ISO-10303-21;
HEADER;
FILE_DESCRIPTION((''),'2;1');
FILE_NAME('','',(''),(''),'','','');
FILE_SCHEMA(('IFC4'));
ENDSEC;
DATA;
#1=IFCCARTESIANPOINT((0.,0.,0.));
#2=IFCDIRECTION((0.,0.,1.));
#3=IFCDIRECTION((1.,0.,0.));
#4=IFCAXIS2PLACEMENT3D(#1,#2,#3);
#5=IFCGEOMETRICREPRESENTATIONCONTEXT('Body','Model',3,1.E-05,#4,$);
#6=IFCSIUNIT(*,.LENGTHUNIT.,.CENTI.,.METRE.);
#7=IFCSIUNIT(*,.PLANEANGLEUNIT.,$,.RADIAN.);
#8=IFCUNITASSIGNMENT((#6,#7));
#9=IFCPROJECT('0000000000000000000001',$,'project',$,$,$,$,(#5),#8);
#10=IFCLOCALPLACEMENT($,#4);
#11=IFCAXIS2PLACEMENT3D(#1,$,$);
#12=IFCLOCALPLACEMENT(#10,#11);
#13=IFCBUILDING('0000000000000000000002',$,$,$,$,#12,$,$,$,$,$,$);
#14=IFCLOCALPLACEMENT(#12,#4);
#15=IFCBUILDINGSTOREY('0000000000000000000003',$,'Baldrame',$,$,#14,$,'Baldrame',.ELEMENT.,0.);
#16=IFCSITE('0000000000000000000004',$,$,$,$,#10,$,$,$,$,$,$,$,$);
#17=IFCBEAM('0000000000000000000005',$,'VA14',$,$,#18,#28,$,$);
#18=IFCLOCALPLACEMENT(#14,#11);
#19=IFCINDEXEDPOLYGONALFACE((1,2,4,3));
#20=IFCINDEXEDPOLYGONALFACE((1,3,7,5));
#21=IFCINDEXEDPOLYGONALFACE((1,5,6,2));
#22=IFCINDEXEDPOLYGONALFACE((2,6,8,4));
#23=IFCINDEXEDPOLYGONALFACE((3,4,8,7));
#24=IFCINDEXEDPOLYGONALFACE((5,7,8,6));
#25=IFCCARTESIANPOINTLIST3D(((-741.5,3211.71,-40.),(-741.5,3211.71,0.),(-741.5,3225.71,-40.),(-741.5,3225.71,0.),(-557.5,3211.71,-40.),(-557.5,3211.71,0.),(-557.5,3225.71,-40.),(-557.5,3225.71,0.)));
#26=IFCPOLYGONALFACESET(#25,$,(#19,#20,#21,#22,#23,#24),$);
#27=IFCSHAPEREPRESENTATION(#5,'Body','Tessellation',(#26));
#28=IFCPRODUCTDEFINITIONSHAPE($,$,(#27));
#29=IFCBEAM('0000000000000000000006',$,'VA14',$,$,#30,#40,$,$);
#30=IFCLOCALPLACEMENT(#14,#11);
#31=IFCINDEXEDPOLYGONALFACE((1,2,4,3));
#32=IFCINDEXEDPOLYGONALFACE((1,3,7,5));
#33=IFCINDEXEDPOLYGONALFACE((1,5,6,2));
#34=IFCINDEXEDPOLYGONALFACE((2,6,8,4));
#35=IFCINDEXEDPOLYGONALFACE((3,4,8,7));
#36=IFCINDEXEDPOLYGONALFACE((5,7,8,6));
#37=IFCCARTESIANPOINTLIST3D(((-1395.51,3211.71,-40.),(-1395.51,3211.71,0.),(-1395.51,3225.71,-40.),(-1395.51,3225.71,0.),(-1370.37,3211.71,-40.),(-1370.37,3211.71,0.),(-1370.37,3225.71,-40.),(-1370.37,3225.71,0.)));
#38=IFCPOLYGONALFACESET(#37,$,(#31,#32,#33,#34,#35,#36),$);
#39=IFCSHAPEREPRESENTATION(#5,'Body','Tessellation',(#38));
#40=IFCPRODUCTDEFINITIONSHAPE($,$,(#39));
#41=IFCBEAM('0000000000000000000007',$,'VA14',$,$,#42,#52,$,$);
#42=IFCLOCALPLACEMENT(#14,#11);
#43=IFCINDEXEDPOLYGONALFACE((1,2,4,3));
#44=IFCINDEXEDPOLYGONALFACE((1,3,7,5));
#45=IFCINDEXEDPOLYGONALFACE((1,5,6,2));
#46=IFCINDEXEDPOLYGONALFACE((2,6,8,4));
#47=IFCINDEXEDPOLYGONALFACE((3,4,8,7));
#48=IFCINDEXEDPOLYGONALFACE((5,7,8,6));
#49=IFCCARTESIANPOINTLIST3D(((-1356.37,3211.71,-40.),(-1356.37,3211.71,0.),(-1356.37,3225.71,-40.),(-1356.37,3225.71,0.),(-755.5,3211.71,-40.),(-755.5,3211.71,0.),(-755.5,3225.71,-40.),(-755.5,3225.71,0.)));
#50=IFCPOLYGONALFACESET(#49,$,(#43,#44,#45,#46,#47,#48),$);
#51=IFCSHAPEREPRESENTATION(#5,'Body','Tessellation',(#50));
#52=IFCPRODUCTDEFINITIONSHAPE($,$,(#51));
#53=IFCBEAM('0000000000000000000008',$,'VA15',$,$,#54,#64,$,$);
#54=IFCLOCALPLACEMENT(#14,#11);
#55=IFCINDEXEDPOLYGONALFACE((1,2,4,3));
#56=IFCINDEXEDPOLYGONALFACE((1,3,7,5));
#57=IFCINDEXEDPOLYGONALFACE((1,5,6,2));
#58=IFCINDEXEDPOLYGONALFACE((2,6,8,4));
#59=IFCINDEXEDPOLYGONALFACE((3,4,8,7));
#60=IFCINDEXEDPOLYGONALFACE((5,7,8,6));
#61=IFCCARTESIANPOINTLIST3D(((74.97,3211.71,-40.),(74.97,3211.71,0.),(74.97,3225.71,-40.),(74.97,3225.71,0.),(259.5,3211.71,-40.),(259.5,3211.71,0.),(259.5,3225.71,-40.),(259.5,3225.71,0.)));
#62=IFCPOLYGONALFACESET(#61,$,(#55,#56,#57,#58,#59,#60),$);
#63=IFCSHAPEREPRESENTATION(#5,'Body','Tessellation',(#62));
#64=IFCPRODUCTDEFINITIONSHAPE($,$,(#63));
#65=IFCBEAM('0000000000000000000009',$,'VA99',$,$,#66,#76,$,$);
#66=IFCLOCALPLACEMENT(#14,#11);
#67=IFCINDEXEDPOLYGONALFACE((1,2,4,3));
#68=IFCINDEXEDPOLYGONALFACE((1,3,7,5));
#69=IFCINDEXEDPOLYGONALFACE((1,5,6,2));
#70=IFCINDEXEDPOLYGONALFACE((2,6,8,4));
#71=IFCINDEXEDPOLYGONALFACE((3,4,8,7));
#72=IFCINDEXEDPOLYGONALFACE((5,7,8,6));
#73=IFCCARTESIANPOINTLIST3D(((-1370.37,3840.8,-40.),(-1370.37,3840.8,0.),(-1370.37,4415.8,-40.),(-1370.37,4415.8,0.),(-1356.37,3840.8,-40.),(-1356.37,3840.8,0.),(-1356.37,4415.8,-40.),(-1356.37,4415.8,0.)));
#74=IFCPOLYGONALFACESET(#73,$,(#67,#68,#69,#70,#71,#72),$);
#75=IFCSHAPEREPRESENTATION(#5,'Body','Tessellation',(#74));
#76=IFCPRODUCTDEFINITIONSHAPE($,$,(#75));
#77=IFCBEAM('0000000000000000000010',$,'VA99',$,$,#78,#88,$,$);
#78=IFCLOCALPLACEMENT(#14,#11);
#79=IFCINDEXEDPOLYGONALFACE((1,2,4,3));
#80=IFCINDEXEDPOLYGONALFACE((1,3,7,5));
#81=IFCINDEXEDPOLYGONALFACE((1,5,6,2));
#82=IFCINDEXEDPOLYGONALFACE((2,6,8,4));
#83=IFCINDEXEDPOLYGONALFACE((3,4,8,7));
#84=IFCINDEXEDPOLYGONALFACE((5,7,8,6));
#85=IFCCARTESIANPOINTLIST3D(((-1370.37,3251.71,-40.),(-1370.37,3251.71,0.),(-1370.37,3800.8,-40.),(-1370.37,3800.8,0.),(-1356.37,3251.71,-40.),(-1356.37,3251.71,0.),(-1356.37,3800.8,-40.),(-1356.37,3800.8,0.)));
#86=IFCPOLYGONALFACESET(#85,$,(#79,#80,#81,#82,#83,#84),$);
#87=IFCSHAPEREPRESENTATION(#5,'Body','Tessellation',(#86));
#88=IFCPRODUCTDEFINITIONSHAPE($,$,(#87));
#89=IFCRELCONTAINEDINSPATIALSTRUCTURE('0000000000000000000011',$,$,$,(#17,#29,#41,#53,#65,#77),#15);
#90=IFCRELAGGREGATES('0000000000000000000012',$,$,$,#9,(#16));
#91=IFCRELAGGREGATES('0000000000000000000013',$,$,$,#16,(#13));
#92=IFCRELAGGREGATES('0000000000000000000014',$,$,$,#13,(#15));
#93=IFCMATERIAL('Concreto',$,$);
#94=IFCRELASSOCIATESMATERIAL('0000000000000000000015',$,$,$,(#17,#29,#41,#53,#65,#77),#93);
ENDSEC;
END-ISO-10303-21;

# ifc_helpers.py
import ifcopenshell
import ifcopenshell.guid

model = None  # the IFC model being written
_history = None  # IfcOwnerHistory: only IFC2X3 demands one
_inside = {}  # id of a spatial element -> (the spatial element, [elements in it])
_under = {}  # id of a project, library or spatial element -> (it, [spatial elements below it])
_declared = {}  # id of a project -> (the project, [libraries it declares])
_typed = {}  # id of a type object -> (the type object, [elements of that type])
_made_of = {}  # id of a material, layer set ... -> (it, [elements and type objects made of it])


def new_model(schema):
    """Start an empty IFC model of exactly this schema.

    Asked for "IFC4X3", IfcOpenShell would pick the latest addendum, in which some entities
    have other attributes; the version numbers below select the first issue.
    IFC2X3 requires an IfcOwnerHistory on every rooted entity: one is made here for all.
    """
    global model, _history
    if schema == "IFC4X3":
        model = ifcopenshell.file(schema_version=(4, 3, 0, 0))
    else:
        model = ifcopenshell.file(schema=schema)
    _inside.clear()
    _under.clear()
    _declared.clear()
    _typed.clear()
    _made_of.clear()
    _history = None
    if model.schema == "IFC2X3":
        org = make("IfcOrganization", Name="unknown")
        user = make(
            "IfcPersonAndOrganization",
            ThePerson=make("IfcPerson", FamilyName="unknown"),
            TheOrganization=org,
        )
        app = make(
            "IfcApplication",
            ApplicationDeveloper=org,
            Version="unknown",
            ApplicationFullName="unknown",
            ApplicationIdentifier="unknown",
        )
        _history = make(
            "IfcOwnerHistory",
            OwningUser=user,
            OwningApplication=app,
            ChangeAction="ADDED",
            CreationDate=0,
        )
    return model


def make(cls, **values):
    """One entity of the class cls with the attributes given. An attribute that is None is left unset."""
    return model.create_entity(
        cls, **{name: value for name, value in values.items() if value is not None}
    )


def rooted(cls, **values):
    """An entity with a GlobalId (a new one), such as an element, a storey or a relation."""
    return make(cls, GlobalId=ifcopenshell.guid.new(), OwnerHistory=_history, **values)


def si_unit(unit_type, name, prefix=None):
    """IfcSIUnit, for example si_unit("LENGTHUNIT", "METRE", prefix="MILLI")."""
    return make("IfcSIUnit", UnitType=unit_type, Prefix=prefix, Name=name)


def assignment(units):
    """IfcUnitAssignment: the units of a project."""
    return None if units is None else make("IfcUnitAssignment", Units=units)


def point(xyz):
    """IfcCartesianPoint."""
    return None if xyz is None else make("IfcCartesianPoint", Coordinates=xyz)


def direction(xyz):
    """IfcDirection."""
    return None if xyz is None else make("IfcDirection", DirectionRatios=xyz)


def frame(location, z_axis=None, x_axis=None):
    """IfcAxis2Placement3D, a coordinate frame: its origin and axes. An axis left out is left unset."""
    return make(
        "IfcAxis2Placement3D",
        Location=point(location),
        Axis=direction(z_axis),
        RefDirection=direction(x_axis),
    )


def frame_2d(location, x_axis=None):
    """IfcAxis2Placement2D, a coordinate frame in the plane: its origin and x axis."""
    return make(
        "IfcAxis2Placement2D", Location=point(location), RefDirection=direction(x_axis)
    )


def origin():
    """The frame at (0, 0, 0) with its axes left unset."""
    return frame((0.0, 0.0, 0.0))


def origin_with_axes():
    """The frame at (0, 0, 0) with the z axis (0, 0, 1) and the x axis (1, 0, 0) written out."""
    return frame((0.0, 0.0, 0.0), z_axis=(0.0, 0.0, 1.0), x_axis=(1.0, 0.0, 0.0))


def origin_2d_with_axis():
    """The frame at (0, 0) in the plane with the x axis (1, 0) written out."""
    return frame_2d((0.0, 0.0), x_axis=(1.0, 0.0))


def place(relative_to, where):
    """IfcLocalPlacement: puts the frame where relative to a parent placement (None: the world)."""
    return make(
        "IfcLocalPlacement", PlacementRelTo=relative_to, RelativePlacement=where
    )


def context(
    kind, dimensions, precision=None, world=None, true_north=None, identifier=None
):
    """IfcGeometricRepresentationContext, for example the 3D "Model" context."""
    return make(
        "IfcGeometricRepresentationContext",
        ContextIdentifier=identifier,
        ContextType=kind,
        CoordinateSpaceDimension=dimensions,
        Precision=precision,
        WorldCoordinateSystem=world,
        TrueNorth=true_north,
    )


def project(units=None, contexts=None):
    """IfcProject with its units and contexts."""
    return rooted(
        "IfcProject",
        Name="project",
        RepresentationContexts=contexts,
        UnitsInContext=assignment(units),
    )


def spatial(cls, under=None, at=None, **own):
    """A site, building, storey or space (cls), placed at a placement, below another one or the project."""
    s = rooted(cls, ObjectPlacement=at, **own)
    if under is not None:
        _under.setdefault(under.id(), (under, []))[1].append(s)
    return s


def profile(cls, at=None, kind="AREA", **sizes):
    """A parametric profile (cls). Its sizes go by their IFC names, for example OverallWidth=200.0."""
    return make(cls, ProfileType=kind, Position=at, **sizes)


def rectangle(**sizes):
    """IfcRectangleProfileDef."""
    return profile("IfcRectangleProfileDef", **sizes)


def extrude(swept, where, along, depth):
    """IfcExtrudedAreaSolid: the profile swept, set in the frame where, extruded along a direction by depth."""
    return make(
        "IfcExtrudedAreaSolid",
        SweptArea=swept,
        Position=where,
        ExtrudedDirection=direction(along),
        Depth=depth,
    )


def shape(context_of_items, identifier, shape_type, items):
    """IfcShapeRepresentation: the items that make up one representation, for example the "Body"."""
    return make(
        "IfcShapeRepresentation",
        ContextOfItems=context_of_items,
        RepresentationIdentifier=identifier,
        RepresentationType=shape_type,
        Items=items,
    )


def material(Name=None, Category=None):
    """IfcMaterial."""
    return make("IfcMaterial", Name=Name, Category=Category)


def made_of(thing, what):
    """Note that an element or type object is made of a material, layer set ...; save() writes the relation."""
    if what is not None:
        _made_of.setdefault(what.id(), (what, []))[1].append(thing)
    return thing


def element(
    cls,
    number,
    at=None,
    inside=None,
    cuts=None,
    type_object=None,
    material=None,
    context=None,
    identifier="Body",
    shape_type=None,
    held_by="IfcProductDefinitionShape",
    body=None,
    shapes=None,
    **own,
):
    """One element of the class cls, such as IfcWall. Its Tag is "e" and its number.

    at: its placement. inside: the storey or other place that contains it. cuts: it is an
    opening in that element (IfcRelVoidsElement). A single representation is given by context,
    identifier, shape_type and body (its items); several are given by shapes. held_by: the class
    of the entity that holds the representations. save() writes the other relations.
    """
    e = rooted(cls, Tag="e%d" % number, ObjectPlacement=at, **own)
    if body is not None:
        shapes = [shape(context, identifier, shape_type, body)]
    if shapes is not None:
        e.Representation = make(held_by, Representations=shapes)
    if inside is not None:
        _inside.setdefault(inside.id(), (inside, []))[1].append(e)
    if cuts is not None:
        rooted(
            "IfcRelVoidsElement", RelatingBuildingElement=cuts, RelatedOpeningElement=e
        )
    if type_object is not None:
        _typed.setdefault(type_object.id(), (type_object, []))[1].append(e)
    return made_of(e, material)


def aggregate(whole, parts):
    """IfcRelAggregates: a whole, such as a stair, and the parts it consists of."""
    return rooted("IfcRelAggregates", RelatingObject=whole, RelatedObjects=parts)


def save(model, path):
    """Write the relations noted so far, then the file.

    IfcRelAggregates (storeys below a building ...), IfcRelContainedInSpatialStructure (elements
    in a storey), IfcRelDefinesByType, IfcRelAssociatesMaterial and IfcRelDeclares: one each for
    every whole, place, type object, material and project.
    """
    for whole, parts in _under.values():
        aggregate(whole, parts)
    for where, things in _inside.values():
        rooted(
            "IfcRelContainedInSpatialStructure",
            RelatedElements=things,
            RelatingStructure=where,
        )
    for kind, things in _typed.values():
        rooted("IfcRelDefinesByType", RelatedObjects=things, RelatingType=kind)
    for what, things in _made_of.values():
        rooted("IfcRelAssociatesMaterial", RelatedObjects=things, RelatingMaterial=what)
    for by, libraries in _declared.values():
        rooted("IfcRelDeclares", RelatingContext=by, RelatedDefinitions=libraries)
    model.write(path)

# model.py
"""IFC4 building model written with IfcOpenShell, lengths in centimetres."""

from ifc_helpers import new_model, si_unit, frame, origin, origin_with_axes, origin_2d_with_axis, place, context, project, spatial, rectangle, extrude, material, element, save


model = new_model("IFC4")

# Units and contexts
model_context = context("Model", 3, precision=1e-05, world=origin_with_axes(), identifier="Body")
ifc_project = project(units=[si_unit("LENGTHUNIT", "METRE", prefix="CENTI"), si_unit("PLANEANGLEUNIT", "RADIAN")], contexts=[model_context])

# Site, building, storey
site_placement = place(None, origin_with_axes())
site = spatial("IfcSite", under=ifc_project, at=site_placement)
building_placement = place(site_placement, origin())
building = spatial("IfcBuilding", under=site, at=building_placement)
storey_placement = place(building_placement, origin_with_axes())
storey = spatial("IfcBuildingStorey", under=building, at=storey_placement, Name="Baldrame", LongName="Baldrame", CompositionType="ELEMENT", Elevation=0.0)

# Shared definitions
ifc_material = material(Name="Concreto")

# Beams
beam_1_placement = place(storey_placement, frame((-649.5, 3218.71, 0.0), z_axis=(0.0, 0.0, 1.0), x_axis=(1.0, 0.0, 0.0)))
element("IfcBeam", 1, at=beam_1_placement, inside=storey, material=ifc_material, Name="VA14", context=model_context, shape_type="SolidModel", body=[
    extrude(rectangle(XDim=14.0, YDim=40.0, at=origin_2d_with_axis()), frame((-92.0, 0.0, -20.0), z_axis=(1.0, 0.0, 0.0), x_axis=(0.0, 1.0, 0.0)), (0.0, 0.0, 1.0), 184.0),
])
beam_2_placement = place(storey_placement, frame((-1382.94, 3218.71, 0.0), z_axis=(0.0, 0.0, 1.0), x_axis=(1.0, 0.0, 0.0)))
element("IfcBeam", 2, at=beam_2_placement, inside=storey, material=ifc_material, Name="VA14", context=model_context, shape_type="SolidModel", body=[
    extrude(rectangle(XDim=14.0, YDim=40.0, at=origin_2d_with_axis()), frame((-12.57, 0.0, -20.0), z_axis=(1.0, 0.0, 0.0), x_axis=(0.0, 1.0, 0.0)), (0.0, 0.0, 1.0), 25.14),
])
beam_3_placement = place(storey_placement, frame((-1055.93, 3218.71, 0.0), z_axis=(0.0, 0.0, 1.0), x_axis=(1.0, 0.0, 0.0)))
element("IfcBeam", 3, at=beam_3_placement, inside=storey, material=ifc_material, Name="VA14", context=model_context, shape_type="SolidModel", body=[
    extrude(rectangle(XDim=14.0, YDim=40.0, at=origin_2d_with_axis()), frame((-300.44, 0.0, -20.0), z_axis=(1.0, 0.0, 0.0), x_axis=(0.0, 1.0, 0.0)), (0.0, 0.0, 1.0), 600.87),
])
beam_4_placement = place(storey_placement, frame((167.24, 3218.71, 0.0), z_axis=(0.0, 0.0, 1.0), x_axis=(1.0, 0.0, 0.0)))
element("IfcBeam", 4, at=beam_4_placement, inside=storey, material=ifc_material, Name="VA15", context=model_context, shape_type="SolidModel", body=[
    extrude(rectangle(XDim=14.0, YDim=40.0, at=origin_2d_with_axis()), frame((-92.27, 0.0, -20.0), z_axis=(1.0, 0.0, 0.0), x_axis=(0.0, 1.0, 0.0)), (0.0, 0.0, 1.0), 184.53),
])
beam_5_placement = place(storey_placement, frame((-1363.37, 4128.3, 0.0), z_axis=(0.0, 0.0, 1.0), x_axis=(1.0, 0.0, 0.0)))
element("IfcBeam", 5, at=beam_5_placement, inside=storey, material=ifc_material, Name="VA99", context=model_context, shape_type="SolidModel", body=[
    extrude(rectangle(XDim=14.0, YDim=40.0, at=origin_2d_with_axis()), frame((0.0, -287.5, -20.0), z_axis=(0.0, 1.0, 0.0), x_axis=(-1.0, 0.0, 0.0)), (0.0, 0.0, 1.0), 575.0),
])
beam_6_placement = place(storey_placement, frame((-1363.37, 3526.26, 0.0), z_axis=(0.0, 0.0, 1.0), x_axis=(1.0, 0.0, 0.0)))
element("IfcBeam", 6, at=beam_6_placement, inside=storey, material=ifc_material, Name="VA99", context=model_context, shape_type="SolidModel", body=[
    extrude(rectangle(XDim=14.0, YDim=40.0, at=origin_2d_with_axis()), frame((0.0, -274.55, -20.0), z_axis=(0.0, 1.0, 0.0), x_axis=(-1.0, 0.0, 0.0)), (0.0, 0.0, 1.0), 549.09),
])

save(model, "model.ifc")
